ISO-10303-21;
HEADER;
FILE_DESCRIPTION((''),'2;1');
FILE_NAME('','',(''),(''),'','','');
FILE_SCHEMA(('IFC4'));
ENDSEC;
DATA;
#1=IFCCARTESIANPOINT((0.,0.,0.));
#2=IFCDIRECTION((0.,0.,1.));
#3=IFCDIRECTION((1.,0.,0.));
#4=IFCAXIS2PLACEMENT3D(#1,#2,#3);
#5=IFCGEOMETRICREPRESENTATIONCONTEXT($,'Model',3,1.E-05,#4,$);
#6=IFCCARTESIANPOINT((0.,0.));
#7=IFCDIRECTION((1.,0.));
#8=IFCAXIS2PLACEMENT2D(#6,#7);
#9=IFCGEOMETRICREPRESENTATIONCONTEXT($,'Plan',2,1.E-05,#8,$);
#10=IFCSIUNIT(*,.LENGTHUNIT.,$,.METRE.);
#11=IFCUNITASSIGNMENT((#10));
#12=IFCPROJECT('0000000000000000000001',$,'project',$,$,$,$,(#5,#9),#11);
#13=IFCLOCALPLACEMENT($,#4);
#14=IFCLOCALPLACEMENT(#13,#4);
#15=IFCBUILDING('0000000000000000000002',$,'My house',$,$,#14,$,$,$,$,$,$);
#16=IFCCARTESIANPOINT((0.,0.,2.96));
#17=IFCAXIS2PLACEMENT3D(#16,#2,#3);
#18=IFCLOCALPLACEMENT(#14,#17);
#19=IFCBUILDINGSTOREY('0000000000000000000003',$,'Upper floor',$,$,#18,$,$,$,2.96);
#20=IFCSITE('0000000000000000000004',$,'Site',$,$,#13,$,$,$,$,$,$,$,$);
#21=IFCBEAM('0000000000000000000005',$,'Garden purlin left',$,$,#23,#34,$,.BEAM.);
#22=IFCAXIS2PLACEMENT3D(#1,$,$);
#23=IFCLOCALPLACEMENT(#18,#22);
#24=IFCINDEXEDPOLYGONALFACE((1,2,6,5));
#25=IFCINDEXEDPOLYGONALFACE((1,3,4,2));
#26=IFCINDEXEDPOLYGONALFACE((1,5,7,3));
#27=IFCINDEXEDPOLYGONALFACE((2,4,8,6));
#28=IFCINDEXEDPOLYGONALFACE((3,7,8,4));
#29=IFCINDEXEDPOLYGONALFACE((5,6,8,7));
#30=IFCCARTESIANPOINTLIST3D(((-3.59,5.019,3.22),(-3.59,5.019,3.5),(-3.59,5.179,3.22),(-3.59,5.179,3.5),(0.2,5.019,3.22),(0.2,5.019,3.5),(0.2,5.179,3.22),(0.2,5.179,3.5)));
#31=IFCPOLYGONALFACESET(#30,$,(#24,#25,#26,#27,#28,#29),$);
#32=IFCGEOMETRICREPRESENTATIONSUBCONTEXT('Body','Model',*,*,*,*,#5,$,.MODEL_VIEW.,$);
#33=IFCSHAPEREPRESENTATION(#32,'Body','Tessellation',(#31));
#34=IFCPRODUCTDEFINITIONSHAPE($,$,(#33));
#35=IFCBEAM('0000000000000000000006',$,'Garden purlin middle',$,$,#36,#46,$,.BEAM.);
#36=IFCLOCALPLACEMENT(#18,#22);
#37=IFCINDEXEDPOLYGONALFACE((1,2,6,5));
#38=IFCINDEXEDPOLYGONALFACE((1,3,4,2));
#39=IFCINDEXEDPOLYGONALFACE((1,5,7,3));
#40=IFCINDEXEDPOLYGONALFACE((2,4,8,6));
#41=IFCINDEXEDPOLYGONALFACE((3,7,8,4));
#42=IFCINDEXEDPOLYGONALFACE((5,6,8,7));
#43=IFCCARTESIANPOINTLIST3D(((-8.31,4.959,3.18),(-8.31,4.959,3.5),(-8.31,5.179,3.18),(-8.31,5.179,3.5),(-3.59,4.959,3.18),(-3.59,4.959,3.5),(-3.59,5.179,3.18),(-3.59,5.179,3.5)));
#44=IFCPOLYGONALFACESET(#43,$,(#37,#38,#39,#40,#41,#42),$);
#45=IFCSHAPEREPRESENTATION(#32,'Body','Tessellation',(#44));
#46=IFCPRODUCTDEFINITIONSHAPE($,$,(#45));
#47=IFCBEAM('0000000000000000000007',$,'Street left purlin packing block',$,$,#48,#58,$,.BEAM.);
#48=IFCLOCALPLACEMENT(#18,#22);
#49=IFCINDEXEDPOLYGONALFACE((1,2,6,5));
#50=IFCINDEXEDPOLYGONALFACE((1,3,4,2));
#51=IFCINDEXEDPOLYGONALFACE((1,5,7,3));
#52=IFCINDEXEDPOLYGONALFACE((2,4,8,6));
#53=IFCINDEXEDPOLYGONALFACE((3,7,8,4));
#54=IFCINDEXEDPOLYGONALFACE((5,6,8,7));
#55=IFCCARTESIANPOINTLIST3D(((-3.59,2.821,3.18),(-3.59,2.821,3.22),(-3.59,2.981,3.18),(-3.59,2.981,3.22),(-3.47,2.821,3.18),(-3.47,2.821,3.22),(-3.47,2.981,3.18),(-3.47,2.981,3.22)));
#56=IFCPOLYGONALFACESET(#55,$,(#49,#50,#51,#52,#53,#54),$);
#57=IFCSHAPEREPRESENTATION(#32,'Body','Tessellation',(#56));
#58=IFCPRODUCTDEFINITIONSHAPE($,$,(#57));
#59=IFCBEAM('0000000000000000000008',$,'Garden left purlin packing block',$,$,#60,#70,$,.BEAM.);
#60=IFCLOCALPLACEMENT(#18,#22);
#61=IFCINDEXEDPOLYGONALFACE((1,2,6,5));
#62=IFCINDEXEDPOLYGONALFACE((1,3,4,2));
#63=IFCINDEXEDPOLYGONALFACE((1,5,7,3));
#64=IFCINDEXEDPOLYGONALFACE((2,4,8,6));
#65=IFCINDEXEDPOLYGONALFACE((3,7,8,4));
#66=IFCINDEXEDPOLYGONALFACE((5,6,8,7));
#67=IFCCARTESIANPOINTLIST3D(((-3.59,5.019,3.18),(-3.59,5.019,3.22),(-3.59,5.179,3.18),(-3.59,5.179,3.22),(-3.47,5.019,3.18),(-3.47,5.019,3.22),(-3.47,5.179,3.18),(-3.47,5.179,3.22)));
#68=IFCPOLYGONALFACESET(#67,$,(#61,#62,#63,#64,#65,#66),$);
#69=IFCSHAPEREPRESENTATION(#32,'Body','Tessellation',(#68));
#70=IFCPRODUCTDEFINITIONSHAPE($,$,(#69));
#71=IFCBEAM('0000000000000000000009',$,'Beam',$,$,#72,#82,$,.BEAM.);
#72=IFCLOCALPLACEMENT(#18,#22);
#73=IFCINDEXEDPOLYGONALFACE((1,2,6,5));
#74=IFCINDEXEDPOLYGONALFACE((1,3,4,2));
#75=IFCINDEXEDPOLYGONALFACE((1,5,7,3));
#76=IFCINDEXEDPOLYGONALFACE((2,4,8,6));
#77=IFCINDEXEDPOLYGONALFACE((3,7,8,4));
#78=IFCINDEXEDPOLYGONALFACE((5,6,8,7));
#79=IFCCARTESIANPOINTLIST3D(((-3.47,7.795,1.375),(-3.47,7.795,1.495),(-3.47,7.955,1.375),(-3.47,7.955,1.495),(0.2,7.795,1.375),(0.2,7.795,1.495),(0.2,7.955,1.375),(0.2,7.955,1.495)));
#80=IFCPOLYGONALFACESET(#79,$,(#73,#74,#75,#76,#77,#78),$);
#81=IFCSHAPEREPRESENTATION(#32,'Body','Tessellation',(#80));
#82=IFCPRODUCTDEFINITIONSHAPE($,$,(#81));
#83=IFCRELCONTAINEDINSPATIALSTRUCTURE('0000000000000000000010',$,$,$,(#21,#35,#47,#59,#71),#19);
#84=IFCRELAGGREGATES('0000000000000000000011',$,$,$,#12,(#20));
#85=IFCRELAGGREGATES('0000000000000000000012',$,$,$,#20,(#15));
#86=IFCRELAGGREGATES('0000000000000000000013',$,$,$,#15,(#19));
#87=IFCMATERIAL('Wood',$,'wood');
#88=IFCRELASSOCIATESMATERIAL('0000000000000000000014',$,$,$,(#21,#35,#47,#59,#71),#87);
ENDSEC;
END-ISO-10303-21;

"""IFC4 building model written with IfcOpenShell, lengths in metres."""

from ifc_helpers import new_model, si_unit, frame, origin_with_axes, origin_2d_with_axis, place, context, subcontext, project, spatial, rectangle, extrude, source, transform, mapped, material, element, save


model = new_model("IFC4")

# Units and contexts
model_context = context("Model", 3, precision=1e-05, world=origin_with_axes())
plan_context = context("Plan", 2, precision=1e-05, world=origin_2d_with_axis())
body_context_1 = subcontext(model_context, "Body", "Model", "MODEL_VIEW")
ifc_project = project(units=[si_unit("LENGTHUNIT", "METRE")], contexts=[model_context, plan_context])

# Site, building, storey
site_placement = place(None, origin_with_axes())
site = spatial("IfcSite", under=ifc_project, at=site_placement, Name="Site")
building_placement = place(site_placement, origin_with_axes())
building = spatial("IfcBuilding", under=site, at=building_placement, Name="My house")
storey_placement = place(building_placement, frame((0.0, 0.0, 2.96), z_axis=(0.0, 0.0, 1.0), x_axis=(1.0, 0.0, 0.0)))
storey = spatial("IfcBuildingStorey", under=building, at=storey_placement, Name="Upper floor", Elevation=2.96)

# Beams
ifc_material_1 = material(Name="Wood", Category="wood")
shared_shape_1 = source(origin_with_axes(), body_context_1, "Body", "SweptSolid", [
    extrude(rectangle(XDim=0.16, YDim=0.28), frame((0.0, 0.0, 0.0), z_axis=(1.0, 0.0, 0.0), x_axis=(0.0, 1.0, 0.0)), (0.0, 0.0, 1.0), 3.79),
])
beam_1_placement = place(storey_placement, frame((0.2, 5.099, 3.36), z_axis=(0.0, 0.0, 1.0), x_axis=(1.0, 0.0, 0.0)))
element("IfcBeam", 1, at=beam_1_placement, inside=storey, material=ifc_material_1, Name="Garden purlin left", PredefinedType="BEAM", context=body_context_1, shape_type="MappedRepresentation", body=[
    mapped(shared_shape_1, transform((0.0, 0.0, 0.0), x_axis=(-1.0, 0.0, 0.0), y_axis=(0.0, 1.0, 0.0), z_axis=(0.0, 0.0, 1.0), scale=1.0)),
])
shared_shape_2 = source(origin_with_axes(), body_context_1, "Body", "SweptSolid", [
    extrude(rectangle(XDim=0.22, YDim=0.32), frame((0.0, 0.0, 0.0), z_axis=(1.0, 0.0, 0.0), x_axis=(0.0, 1.0, 0.0)), (0.0, 0.0, 1.0), 4.72),
])
beam_2_placement = place(storey_placement, frame((-3.59, 5.069, 3.34), z_axis=(0.0, 0.0, 1.0), x_axis=(1.0, 0.0, 0.0)))
element("IfcBeam", 2, at=beam_2_placement, inside=storey, material=ifc_material_1, Name="Garden purlin middle", PredefinedType="BEAM", context=body_context_1, shape_type="MappedRepresentation", body=[
    mapped(shared_shape_2, transform((0.0, 0.0, 0.0), x_axis=(-1.0, 0.0, 0.0), y_axis=(0.0, 1.0, 0.0), z_axis=(0.0, 0.0, 1.0), scale=1.0)),
])
shared_shape_3 = source(origin_with_axes(), body_context_1, "Body", "SweptSolid", [
    extrude(rectangle(XDim=0.16, YDim=0.04), frame((0.0, 0.0, 0.0), z_axis=(1.0, 0.0, 0.0), x_axis=(0.0, 1.0, 0.0)), (0.0, 0.0, 1.0), 0.12),
])
beam_3_placement = place(storey_placement, frame((-3.47, 2.901, 3.2), z_axis=(0.0, 0.0, 1.0), x_axis=(1.0, 0.0, 0.0)))
element("IfcBeam", 3, at=beam_3_placement, inside=storey, material=ifc_material_1, Name="Street left purlin packing block", PredefinedType="BEAM", context=body_context_1, shape_type="MappedRepresentation", body=[
    mapped(shared_shape_3, transform((0.0, 0.0, 0.0), x_axis=(-1.0, 0.0, 0.0), y_axis=(0.0, 1.0, 0.0), z_axis=(0.0, 0.0, 1.0), scale=1.0)),
])
shared_shape_4 = source(origin_with_axes(), body_context_1, "Body", "SweptSolid", [
    extrude(rectangle(XDim=0.16, YDim=0.04), frame((0.0, 0.0, 0.0), z_axis=(1.0, 0.0, 0.0), x_axis=(0.0, 1.0, 0.0)), (0.0, 0.0, 1.0), 0.12),
])
beam_4_placement = place(storey_placement, frame((-3.47, 5.099, 3.2), z_axis=(0.0, 0.0, 1.0), x_axis=(1.0, 0.0, 0.0)))
element("IfcBeam", 4, at=beam_4_placement, inside=storey, material=ifc_material_1, Name="Garden left purlin packing block", PredefinedType="BEAM", context=body_context_1, shape_type="MappedRepresentation", body=[
    mapped(shared_shape_4, transform((0.0, 0.0, 0.0), x_axis=(-1.0, 0.0, 0.0), y_axis=(0.0, 1.0, 0.0), z_axis=(0.0, 0.0, 1.0), scale=1.0)),
])
shared_shape_5 = source(origin_with_axes(), body_context_1, "Body", "SweptSolid", [
    extrude(rectangle(XDim=0.16, YDim=0.12), frame((0.0, 0.0, 0.0), z_axis=(1.0, 0.0, 0.0), x_axis=(0.0, 1.0, 0.0)), (0.0, 0.0, 1.0), 3.67),
])
beam_5_placement = place(storey_placement, frame((0.2, 7.875, 1.435), z_axis=(0.0, 0.0, 1.0), x_axis=(1.0, 0.0, 0.0)))
element("IfcBeam", 5, at=beam_5_placement, inside=storey, material=ifc_material_1, Name="Beam", PredefinedType="BEAM", context=body_context_1, shape_type="MappedRepresentation", body=[
    mapped(shared_shape_5, transform((0.0, 0.0, 0.0), x_axis=(-1.0, 0.0, 0.0), y_axis=(0.0, 1.0, 0.0), z_axis=(0.0, 0.0, 1.0), scale=1.0)),
])

save(model, "model.ifc")
